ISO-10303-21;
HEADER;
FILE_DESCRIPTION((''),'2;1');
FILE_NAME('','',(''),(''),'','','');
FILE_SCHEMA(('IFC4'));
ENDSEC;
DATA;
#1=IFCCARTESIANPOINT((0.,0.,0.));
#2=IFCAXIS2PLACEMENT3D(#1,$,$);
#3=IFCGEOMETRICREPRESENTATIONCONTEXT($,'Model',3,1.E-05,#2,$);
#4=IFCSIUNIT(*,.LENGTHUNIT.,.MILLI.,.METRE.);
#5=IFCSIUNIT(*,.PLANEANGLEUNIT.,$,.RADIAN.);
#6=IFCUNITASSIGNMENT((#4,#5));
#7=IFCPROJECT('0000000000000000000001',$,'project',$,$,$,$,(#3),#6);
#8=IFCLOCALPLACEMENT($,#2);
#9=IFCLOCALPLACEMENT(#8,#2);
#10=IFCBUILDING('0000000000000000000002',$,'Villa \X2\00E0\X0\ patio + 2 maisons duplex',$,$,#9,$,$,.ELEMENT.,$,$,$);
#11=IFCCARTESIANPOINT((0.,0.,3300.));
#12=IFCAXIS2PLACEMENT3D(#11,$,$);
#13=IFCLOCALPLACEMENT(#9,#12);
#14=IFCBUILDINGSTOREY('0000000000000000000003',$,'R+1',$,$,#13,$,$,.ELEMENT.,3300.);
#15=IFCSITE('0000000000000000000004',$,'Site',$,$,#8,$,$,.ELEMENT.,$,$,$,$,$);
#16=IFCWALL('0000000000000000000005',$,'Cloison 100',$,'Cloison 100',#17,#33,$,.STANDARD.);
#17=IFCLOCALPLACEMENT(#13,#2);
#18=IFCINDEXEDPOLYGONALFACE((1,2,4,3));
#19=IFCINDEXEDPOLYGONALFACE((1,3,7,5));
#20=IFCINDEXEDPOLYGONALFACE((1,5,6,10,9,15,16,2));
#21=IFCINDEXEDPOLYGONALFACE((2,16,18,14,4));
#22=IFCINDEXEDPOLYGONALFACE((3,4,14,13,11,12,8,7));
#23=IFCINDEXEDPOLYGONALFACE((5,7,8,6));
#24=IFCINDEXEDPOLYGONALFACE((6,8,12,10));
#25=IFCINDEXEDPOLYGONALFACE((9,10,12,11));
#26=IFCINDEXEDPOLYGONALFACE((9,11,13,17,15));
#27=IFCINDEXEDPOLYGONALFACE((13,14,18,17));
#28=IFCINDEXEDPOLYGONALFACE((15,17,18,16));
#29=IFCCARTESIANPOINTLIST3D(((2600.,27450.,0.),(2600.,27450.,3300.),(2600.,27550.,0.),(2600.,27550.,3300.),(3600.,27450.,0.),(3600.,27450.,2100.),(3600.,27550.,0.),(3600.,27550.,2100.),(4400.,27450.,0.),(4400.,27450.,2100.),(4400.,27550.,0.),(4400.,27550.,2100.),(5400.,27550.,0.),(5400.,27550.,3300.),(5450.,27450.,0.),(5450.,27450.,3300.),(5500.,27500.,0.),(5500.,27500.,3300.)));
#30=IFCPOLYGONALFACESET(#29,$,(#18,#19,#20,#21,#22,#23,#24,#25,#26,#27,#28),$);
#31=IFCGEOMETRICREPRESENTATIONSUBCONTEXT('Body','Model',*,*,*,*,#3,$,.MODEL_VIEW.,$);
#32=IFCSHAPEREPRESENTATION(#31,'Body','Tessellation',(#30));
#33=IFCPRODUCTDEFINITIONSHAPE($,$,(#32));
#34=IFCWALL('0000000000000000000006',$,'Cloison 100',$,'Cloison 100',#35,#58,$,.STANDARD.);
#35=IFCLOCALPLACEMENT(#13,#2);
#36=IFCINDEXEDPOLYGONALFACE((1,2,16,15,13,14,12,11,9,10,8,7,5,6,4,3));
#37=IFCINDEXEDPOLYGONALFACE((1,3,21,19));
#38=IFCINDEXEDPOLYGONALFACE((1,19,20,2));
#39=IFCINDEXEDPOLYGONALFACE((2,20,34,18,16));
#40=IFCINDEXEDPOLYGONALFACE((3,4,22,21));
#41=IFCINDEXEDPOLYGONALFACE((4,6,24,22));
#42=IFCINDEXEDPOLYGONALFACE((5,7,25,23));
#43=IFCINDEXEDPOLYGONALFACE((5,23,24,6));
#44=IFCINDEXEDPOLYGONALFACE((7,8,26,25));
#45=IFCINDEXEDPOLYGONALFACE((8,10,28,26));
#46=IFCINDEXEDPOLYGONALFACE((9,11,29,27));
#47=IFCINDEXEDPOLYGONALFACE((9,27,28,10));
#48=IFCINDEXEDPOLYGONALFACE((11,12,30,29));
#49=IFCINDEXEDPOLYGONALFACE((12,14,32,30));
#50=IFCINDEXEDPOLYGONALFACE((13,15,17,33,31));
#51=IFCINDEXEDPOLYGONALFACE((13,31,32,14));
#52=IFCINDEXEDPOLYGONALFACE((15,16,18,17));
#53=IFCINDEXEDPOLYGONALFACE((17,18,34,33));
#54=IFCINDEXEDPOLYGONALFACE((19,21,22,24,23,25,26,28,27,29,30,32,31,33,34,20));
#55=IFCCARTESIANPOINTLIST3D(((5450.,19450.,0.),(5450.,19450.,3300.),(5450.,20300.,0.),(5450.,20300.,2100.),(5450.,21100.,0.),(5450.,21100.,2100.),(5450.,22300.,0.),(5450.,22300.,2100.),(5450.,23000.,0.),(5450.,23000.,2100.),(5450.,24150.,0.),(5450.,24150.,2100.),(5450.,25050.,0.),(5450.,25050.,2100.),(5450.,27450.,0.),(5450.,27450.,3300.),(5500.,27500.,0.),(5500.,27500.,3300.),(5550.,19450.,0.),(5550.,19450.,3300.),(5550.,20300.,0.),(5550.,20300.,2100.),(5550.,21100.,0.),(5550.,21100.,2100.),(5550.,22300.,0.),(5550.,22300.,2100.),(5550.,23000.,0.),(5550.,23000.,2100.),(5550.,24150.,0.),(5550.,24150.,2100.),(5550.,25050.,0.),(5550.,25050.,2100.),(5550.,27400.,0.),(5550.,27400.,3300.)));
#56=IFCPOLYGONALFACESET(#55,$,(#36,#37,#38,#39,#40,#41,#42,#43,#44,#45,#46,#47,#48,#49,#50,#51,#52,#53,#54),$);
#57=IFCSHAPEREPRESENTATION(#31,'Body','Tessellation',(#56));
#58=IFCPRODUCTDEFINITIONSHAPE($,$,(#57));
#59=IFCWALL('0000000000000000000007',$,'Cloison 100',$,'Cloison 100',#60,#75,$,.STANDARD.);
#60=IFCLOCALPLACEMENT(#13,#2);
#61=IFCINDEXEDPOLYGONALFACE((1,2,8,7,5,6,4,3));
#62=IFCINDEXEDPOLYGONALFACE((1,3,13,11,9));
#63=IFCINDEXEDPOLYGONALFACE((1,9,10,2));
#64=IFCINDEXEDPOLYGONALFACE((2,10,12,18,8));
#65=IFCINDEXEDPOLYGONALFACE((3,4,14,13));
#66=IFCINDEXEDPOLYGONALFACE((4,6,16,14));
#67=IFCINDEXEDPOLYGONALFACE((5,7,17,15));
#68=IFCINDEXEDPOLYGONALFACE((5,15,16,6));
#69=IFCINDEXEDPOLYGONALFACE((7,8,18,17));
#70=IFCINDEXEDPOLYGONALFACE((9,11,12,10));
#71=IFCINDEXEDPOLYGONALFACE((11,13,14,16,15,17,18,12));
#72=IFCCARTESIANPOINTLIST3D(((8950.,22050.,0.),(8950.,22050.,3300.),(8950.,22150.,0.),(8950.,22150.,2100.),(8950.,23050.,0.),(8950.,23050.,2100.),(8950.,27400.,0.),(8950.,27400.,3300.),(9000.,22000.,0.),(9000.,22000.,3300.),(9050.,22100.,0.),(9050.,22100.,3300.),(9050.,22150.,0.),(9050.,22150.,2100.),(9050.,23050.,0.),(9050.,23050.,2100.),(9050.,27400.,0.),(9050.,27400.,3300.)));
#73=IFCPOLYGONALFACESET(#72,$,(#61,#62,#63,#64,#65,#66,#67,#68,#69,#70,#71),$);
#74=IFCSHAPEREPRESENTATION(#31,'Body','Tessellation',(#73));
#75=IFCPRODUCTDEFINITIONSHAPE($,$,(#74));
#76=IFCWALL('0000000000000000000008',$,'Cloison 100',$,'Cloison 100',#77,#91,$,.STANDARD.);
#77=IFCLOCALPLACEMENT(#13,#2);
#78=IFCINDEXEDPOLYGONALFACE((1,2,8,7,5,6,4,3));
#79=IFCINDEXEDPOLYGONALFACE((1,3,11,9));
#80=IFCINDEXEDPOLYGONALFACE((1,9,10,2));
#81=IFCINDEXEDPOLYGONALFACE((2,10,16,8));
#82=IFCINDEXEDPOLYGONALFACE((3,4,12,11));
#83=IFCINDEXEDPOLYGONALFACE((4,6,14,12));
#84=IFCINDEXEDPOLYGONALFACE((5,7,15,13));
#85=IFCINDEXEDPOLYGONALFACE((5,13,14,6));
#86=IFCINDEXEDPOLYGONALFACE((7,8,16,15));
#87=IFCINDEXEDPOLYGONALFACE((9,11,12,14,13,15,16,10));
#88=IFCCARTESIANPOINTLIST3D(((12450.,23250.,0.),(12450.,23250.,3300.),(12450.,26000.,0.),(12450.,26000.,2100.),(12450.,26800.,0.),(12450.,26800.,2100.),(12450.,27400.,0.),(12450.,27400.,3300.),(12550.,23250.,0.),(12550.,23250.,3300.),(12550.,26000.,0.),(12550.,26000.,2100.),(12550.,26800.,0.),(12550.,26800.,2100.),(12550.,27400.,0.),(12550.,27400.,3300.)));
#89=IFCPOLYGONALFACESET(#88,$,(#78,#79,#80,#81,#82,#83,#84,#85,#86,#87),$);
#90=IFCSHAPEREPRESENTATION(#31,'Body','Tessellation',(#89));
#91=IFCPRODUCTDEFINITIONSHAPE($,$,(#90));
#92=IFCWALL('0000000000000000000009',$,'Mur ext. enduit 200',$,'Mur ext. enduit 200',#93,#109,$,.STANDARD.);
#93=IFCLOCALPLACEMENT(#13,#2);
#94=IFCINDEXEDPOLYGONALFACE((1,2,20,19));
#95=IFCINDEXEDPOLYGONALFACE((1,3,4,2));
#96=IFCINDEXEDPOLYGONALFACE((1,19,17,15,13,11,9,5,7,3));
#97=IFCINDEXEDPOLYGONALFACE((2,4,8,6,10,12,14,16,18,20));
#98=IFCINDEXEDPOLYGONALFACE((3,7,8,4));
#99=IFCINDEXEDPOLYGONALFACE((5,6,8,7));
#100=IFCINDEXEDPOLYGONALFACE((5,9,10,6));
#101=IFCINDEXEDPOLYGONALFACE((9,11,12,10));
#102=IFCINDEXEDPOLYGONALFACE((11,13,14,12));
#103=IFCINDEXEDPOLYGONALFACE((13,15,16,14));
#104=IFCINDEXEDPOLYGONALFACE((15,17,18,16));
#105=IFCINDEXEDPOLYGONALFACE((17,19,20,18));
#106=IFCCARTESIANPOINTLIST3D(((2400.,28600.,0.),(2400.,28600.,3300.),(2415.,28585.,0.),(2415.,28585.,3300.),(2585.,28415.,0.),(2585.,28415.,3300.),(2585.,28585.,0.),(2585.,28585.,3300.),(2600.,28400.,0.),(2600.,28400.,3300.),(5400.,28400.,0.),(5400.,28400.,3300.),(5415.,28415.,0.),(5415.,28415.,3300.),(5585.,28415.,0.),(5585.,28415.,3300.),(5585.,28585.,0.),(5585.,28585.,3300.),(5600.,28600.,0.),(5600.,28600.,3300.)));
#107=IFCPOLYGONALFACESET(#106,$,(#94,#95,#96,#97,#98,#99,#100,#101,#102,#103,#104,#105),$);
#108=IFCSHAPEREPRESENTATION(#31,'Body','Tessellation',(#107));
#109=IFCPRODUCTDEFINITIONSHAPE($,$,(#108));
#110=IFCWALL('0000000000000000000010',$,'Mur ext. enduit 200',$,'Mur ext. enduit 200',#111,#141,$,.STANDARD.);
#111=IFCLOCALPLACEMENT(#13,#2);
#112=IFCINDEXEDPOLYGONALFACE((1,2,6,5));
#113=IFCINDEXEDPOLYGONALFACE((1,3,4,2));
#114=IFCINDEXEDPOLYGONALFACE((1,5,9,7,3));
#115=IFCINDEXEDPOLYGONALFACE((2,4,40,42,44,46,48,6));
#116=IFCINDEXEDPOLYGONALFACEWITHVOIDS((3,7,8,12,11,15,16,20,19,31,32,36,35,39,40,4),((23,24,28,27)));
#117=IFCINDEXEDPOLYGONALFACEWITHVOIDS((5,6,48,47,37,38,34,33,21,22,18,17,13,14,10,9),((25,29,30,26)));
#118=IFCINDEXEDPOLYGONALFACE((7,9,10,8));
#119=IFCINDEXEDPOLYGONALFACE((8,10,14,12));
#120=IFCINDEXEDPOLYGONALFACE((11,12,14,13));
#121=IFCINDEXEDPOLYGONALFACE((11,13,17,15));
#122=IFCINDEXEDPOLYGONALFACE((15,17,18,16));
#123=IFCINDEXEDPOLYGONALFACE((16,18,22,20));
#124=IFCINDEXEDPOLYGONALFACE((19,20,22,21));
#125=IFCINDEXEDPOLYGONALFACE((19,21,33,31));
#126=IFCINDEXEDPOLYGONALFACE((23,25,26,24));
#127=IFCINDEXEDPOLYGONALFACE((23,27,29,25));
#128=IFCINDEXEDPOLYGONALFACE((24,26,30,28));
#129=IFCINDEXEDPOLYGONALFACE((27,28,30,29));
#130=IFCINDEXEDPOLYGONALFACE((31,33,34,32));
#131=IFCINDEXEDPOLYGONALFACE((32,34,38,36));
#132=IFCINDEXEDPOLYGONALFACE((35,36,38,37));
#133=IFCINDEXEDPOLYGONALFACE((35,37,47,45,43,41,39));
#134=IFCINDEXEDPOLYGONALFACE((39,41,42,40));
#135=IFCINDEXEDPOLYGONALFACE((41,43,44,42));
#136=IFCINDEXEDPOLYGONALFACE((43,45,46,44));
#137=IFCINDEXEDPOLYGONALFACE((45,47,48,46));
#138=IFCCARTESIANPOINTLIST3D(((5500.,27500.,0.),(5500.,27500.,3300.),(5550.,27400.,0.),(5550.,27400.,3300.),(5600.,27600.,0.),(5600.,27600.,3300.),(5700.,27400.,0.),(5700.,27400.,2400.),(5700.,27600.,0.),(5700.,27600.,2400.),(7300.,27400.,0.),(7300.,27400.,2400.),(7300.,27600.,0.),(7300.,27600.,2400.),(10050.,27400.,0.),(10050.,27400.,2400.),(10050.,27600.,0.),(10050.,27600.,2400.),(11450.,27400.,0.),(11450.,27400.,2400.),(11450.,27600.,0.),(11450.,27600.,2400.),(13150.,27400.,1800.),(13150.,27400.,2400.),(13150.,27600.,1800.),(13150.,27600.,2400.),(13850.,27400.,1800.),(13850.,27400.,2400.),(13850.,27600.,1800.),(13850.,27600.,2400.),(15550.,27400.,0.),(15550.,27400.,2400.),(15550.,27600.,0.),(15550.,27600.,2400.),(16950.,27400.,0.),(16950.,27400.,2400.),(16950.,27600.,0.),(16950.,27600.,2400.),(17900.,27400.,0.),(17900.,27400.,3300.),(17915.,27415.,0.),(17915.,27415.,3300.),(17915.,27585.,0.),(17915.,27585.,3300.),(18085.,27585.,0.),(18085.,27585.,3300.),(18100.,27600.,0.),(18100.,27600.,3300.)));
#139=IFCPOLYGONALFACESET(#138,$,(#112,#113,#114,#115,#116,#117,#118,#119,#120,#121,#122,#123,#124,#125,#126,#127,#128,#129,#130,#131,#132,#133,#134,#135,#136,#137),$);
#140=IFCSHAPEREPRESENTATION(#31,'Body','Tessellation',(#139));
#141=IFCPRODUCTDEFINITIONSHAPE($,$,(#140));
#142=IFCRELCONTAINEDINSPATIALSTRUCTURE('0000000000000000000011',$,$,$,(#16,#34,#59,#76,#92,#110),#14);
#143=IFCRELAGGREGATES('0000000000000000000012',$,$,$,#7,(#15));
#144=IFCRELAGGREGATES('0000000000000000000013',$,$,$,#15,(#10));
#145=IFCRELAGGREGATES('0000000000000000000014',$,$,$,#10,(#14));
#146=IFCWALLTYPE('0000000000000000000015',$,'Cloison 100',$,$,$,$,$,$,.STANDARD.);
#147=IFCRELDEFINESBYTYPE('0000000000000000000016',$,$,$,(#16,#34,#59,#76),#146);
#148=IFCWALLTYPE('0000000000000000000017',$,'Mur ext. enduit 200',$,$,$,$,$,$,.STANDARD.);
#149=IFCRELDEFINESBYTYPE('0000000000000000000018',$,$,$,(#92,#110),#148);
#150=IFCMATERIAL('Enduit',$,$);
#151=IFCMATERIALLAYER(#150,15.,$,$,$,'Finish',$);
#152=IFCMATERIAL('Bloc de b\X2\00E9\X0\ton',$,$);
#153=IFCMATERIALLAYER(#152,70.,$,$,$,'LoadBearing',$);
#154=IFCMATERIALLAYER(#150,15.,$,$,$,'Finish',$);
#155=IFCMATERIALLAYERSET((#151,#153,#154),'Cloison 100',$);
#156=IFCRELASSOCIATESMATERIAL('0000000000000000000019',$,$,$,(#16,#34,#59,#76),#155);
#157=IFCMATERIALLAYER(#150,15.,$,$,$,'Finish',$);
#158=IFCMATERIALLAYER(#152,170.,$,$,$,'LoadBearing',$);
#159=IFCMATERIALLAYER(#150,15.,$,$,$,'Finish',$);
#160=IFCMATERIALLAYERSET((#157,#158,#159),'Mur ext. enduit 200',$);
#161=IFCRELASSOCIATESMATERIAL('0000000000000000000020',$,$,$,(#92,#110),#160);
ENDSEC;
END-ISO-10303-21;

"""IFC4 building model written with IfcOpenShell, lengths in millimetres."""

from ifc_helpers import new_model, si_unit, frame, frame_2d, origin, place, context, subcontext, project, spatial, polyline, rectangle, outline, extrude, material, layer, layer_set, layer_usage, type_object, element, save


model = new_model("IFC4")

# Units and contexts
model_context = context("Model", 3, precision=1e-05, world=origin())
body_context = subcontext(model_context, "Body", "Model", "MODEL_VIEW")
ifc_project = project(units=[si_unit("LENGTHUNIT", "METRE", prefix="MILLI"), si_unit("PLANEANGLEUNIT", "RADIAN")], contexts=[model_context])

# Site, building, storey
site_placement = place(None, origin())
site = spatial("IfcSite", under=ifc_project, at=site_placement, Name="Site", CompositionType="ELEMENT")
building_placement = place(site_placement, origin())
building = spatial("IfcBuilding", under=site, at=building_placement, Name="Villa à patio + 2 maisons duplex", CompositionType="ELEMENT")
storey_placement = place(building_placement, frame((0.0, 0.0, 3300.0)))
storey = spatial("IfcBuildingStorey", under=building, at=storey_placement, Name="R+1", CompositionType="ELEMENT", Elevation=3300.0)

# Wall, opening
ifc_material_1 = material(Name="Enduit")
ifc_layer_1 = layer(ifc_material_1, 15.0, Category="Finish")
ifc_material_2 = material(Name="Bloc de béton")
ifc_layer_2 = layer(ifc_material_2, 70.0, Category="LoadBearing")
ifc_layer_3 = layer(ifc_material_1, 15.0, Category="Finish")
ifc_layer_set_1 = layer_set([ifc_layer_1, ifc_layer_2, ifc_layer_3], Name="Cloison 100")
ifc_layer_usage_1 = layer_usage(ifc_layer_set_1, "AXIS2", "NEGATIVE", 50.0)
wall_type_1 = type_object("IfcWallType", Name="Cloison 100", PredefinedType="STANDARD")
wall_1_placement = place(storey_placement, frame((2500.0, 27500.0, 0.0), z_axis=(0.0, 0.0, 1.0), x_axis=(1.0, 0.0, 0.0)))
wall_1 = element("IfcWall", 1, at=wall_1_placement, inside=storey, type_object=wall_type_1, material=ifc_layer_usage_1, Name="Cloison 100", ObjectType="Cloison 100", PredefinedType="STANDARD", context=body_context, shape_type="SweptSolid", body=[
    extrude(outline(polyline([(100.0, -50.0), (100.0, 50.0), (2900.0, 50.0), (3000.0, 0.0), (2950.0, -50.0), (100.0, -50.0)])), origin(), (0.0, 0.0, 1.0), 3300.0),
])
opening_1_placement = place(wall_1_placement, frame((1100.0, 0.0, 0.0), z_axis=(0.0, 0.0, 1.0), x_axis=(1.0, 0.0, 0.0)))
element("IfcOpeningElement", 2, at=opening_1_placement, cuts=wall_1, PredefinedType="OPENING", context=body_context, shape_type="SweptSolid", body=[
    extrude(rectangle(XDim=800.0, YDim=120.0, at=frame_2d((400.0, 0.0))), origin(), (0.0, 0.0, 1.0), 2100.0),
])

# Wall, openings
wall_2_placement = place(storey_placement, frame((5500.0, 27500.0, 0.0), z_axis=(0.0, 0.0, 1.0), x_axis=(0.0, -1.0, 0.0)))
wall_2 = element("IfcWall", 3, at=wall_2_placement, inside=storey, type_object=wall_type_1, material=ifc_layer_usage_1, Name="Cloison 100", ObjectType="Cloison 100", PredefinedType="STANDARD", context=body_context, shape_type="SweptSolid", body=[
    extrude(outline(polyline([(50.0, -50.0), (0.0, 0.0), (100.0, 50.0), (8050.0, 50.0), (8050.0, -50.0), (50.0, -50.0)])), origin(), (0.0, 0.0, 1.0), 3300.0),
])
opening_2_placement = place(wall_2_placement, frame((2450.0, 0.0, 0.0), z_axis=(0.0, 0.0, 1.0), x_axis=(1.0, 0.0, 0.0)))
element("IfcOpeningElement", 4, at=opening_2_placement, cuts=wall_2, PredefinedType="OPENING", context=body_context, shape_type="SweptSolid", body=[
    extrude(rectangle(XDim=900.0, YDim=120.0, at=frame_2d((450.0, 0.0))), origin(), (0.0, 0.0, 1.0), 2100.0),
])
opening_3_placement = place(wall_2_placement, frame((4500.0, 0.0, 0.0), z_axis=(0.0, 0.0, 1.0), x_axis=(1.0, 0.0, 0.0)))
element("IfcOpeningElement", 5, at=opening_3_placement, cuts=wall_2, PredefinedType="OPENING", context=body_context, shape_type="SweptSolid", body=[
    extrude(rectangle(XDim=700.0, YDim=120.0, at=frame_2d((350.0, 0.0))), origin(), (0.0, 0.0, 1.0), 2100.0),
])
opening_4_placement = place(wall_2_placement, frame((6400.0, 0.0, 0.0), z_axis=(0.0, 0.0, 1.0), x_axis=(1.0, 0.0, 0.0)))
element("IfcOpeningElement", 6, at=opening_4_placement, cuts=wall_2, PredefinedType="OPENING", context=body_context, shape_type="SweptSolid", body=[
    extrude(rectangle(XDim=800.0, YDim=120.0, at=frame_2d((400.0, 0.0))), origin(), (0.0, 0.0, 1.0), 2100.0),
])

# Walls, openings
wall_3_placement = place(storey_placement, frame((9000.0, 27500.0, 0.0), z_axis=(0.0, 0.0, 1.0), x_axis=(0.0, -1.0, 0.0)))
wall_3 = element("IfcWall", 7, at=wall_3_placement, inside=storey, type_object=wall_type_1, material=ifc_layer_usage_1, Name="Cloison 100", ObjectType="Cloison 100", PredefinedType="STANDARD", context=body_context, shape_type="SweptSolid", body=[
    extrude(outline(polyline([(100.0, -50.0), (100.0, 50.0), (5400.0, 50.0), (5500.0, 0.0), (5450.0, -50.0), (100.0, -50.0)])), origin(), (0.0, 0.0, 1.0), 3300.0),
])
opening_5_placement = place(wall_3_placement, frame((4450.0, 0.0, 0.0), z_axis=(0.0, 0.0, 1.0), x_axis=(1.0, 0.0, 0.0)))
element("IfcOpeningElement", 8, at=opening_5_placement, cuts=wall_3, PredefinedType="OPENING", context=body_context, shape_type="SweptSolid", body=[
    extrude(rectangle(XDim=900.0, YDim=120.0, at=frame_2d((450.0, 0.0))), origin(), (0.0, 0.0, 1.0), 2100.0),
])
wall_4_placement = place(storey_placement, frame((12500.0, 27500.0, 0.0), z_axis=(0.0, 0.0, 1.0), x_axis=(0.0, -1.0, 0.0)))
wall_4 = element("IfcWall", 9, at=wall_4_placement, inside=storey, type_object=wall_type_1, material=ifc_layer_usage_1, Name="Cloison 100", ObjectType="Cloison 100", PredefinedType="STANDARD", context=body_context, shape_type="SweptSolid", body=[
    extrude(outline(polyline([(100.0, -50.0), (100.0, 50.0), (4250.0, 50.0), (4250.0, -50.0), (100.0, -50.0)])), origin(), (0.0, 0.0, 1.0), 3300.0),
])
opening_6_placement = place(wall_4_placement, frame((700.0, 0.0, 0.0), z_axis=(0.0, 0.0, 1.0), x_axis=(1.0, 0.0, 0.0)))
element("IfcOpeningElement", 10, at=opening_6_placement, cuts=wall_4, PredefinedType="OPENING", context=body_context, shape_type="SweptSolid", body=[
    extrude(rectangle(XDim=800.0, YDim=120.0, at=frame_2d((400.0, 0.0))), origin(), (0.0, 0.0, 1.0), 2100.0),
])

# Wall
ifc_layer_4 = layer(ifc_material_1, 15.0, Category="Finish")
ifc_layer_5 = layer(ifc_material_2, 170.0, Category="LoadBearing")
ifc_layer_6 = layer(ifc_material_1, 15.0, Category="Finish")
ifc_layer_set_2 = layer_set([ifc_layer_4, ifc_layer_5, ifc_layer_6], Name="Mur ext. enduit 200")
ifc_layer_usage_2 = layer_usage(ifc_layer_set_2, "AXIS2", "NEGATIVE", 100.0)
wall_type_2 = type_object("IfcWallType", Name="Mur ext. enduit 200", PredefinedType="STANDARD")
wall_5_placement = place(storey_placement, frame((2500.0, 28500.0, 0.0), z_axis=(0.0, 0.0, 1.0), x_axis=(1.0, 0.0, 0.0)))
element("IfcWall", 11, at=wall_5_placement, inside=storey, type_object=wall_type_2, material=ifc_layer_usage_2, Name="Mur ext. enduit 200", ObjectType="Mur ext. enduit 200", PredefinedType="STANDARD", context=body_context, shape_type="SweptSolid", body=[
    extrude(outline(polyline([(100.0, -100.0), (85.0, -85.0), (85.0, 85.0), (-85.0, 85.0), (-100.0, 100.0), (3100.0, 100.0), (3085.0, 85.0), (3085.0, -85.0), (2915.0, -85.0), (2900.0, -100.0), (100.0, -100.0)])), origin(), (0.0, 0.0, 1.0), 3300.0),
])

# Wall, openings
wall_6_placement = place(storey_placement, frame((5500.0, 27500.0, 0.0), z_axis=(0.0, 0.0, 1.0), x_axis=(1.0, 0.0, 0.0)))
wall_6 = element("IfcWall", 12, at=wall_6_placement, inside=storey, type_object=wall_type_2, material=ifc_layer_usage_2, Name="Mur ext. enduit 200", ObjectType="Mur ext. enduit 200", PredefinedType="STANDARD", context=body_context, shape_type="SweptSolid", body=[
    extrude(outline(polyline([(50.0, -100.0), (0.0, 0.0), (100.0, 100.0), (12600.0, 100.0), (12585.0, 85.0), (12415.0, 85.0), (12415.0, -85.0), (12400.0, -100.0), (50.0, -100.0)])), origin(), (0.0, 0.0, 1.0), 3300.0),
])
opening_7_placement = place(wall_6_placement, frame((200.0, 0.0, 0.0), z_axis=(0.0, 0.0, 1.0), x_axis=(1.0, 0.0, 0.0)))
element("IfcOpeningElement", 13, at=opening_7_placement, cuts=wall_6, PredefinedType="OPENING", context=body_context, shape_type="SweptSolid", body=[
    extrude(rectangle(XDim=1600.0, YDim=220.0, at=frame_2d((800.0, 0.0))), origin(), (0.0, 0.0, 1.0), 2400.0),
])
opening_8_placement = place(wall_6_placement, frame((4550.0, 0.0, 0.0), z_axis=(0.0, 0.0, 1.0), x_axis=(1.0, 0.0, 0.0)))
element("IfcOpeningElement", 14, at=opening_8_placement, cuts=wall_6, PredefinedType="OPENING", context=body_context, shape_type="SweptSolid", body=[
    extrude(rectangle(XDim=1400.0, YDim=220.0, at=frame_2d((700.0, 0.0))), origin(), (0.0, 0.0, 1.0), 2400.0),
])
opening_9_placement = place(wall_6_placement, frame((7650.0, 0.0, 1800.0), z_axis=(0.0, 0.0, 1.0), x_axis=(1.0, 0.0, 0.0)))
element("IfcOpeningElement", 15, at=opening_9_placement, cuts=wall_6, PredefinedType="OPENING", context=body_context, shape_type="SweptSolid", body=[
    extrude(rectangle(XDim=700.0, YDim=220.0, at=frame_2d((350.0, 0.0))), origin(), (0.0, 0.0, 1.0), 600.0),
])
opening_10_placement = place(wall_6_placement, frame((10050.0, 0.0, 0.0), z_axis=(0.0, 0.0, 1.0), x_axis=(1.0, 0.0, 0.0)))
element("IfcOpeningElement", 16, at=opening_10_placement, cuts=wall_6, PredefinedType="OPENING", context=body_context, shape_type="SweptSolid", body=[
    extrude(rectangle(XDim=1400.0, YDim=220.0, at=frame_2d((700.0, 0.0))), origin(), (0.0, 0.0, 1.0), 2400.0),
])

save(model, "model.ifc")
